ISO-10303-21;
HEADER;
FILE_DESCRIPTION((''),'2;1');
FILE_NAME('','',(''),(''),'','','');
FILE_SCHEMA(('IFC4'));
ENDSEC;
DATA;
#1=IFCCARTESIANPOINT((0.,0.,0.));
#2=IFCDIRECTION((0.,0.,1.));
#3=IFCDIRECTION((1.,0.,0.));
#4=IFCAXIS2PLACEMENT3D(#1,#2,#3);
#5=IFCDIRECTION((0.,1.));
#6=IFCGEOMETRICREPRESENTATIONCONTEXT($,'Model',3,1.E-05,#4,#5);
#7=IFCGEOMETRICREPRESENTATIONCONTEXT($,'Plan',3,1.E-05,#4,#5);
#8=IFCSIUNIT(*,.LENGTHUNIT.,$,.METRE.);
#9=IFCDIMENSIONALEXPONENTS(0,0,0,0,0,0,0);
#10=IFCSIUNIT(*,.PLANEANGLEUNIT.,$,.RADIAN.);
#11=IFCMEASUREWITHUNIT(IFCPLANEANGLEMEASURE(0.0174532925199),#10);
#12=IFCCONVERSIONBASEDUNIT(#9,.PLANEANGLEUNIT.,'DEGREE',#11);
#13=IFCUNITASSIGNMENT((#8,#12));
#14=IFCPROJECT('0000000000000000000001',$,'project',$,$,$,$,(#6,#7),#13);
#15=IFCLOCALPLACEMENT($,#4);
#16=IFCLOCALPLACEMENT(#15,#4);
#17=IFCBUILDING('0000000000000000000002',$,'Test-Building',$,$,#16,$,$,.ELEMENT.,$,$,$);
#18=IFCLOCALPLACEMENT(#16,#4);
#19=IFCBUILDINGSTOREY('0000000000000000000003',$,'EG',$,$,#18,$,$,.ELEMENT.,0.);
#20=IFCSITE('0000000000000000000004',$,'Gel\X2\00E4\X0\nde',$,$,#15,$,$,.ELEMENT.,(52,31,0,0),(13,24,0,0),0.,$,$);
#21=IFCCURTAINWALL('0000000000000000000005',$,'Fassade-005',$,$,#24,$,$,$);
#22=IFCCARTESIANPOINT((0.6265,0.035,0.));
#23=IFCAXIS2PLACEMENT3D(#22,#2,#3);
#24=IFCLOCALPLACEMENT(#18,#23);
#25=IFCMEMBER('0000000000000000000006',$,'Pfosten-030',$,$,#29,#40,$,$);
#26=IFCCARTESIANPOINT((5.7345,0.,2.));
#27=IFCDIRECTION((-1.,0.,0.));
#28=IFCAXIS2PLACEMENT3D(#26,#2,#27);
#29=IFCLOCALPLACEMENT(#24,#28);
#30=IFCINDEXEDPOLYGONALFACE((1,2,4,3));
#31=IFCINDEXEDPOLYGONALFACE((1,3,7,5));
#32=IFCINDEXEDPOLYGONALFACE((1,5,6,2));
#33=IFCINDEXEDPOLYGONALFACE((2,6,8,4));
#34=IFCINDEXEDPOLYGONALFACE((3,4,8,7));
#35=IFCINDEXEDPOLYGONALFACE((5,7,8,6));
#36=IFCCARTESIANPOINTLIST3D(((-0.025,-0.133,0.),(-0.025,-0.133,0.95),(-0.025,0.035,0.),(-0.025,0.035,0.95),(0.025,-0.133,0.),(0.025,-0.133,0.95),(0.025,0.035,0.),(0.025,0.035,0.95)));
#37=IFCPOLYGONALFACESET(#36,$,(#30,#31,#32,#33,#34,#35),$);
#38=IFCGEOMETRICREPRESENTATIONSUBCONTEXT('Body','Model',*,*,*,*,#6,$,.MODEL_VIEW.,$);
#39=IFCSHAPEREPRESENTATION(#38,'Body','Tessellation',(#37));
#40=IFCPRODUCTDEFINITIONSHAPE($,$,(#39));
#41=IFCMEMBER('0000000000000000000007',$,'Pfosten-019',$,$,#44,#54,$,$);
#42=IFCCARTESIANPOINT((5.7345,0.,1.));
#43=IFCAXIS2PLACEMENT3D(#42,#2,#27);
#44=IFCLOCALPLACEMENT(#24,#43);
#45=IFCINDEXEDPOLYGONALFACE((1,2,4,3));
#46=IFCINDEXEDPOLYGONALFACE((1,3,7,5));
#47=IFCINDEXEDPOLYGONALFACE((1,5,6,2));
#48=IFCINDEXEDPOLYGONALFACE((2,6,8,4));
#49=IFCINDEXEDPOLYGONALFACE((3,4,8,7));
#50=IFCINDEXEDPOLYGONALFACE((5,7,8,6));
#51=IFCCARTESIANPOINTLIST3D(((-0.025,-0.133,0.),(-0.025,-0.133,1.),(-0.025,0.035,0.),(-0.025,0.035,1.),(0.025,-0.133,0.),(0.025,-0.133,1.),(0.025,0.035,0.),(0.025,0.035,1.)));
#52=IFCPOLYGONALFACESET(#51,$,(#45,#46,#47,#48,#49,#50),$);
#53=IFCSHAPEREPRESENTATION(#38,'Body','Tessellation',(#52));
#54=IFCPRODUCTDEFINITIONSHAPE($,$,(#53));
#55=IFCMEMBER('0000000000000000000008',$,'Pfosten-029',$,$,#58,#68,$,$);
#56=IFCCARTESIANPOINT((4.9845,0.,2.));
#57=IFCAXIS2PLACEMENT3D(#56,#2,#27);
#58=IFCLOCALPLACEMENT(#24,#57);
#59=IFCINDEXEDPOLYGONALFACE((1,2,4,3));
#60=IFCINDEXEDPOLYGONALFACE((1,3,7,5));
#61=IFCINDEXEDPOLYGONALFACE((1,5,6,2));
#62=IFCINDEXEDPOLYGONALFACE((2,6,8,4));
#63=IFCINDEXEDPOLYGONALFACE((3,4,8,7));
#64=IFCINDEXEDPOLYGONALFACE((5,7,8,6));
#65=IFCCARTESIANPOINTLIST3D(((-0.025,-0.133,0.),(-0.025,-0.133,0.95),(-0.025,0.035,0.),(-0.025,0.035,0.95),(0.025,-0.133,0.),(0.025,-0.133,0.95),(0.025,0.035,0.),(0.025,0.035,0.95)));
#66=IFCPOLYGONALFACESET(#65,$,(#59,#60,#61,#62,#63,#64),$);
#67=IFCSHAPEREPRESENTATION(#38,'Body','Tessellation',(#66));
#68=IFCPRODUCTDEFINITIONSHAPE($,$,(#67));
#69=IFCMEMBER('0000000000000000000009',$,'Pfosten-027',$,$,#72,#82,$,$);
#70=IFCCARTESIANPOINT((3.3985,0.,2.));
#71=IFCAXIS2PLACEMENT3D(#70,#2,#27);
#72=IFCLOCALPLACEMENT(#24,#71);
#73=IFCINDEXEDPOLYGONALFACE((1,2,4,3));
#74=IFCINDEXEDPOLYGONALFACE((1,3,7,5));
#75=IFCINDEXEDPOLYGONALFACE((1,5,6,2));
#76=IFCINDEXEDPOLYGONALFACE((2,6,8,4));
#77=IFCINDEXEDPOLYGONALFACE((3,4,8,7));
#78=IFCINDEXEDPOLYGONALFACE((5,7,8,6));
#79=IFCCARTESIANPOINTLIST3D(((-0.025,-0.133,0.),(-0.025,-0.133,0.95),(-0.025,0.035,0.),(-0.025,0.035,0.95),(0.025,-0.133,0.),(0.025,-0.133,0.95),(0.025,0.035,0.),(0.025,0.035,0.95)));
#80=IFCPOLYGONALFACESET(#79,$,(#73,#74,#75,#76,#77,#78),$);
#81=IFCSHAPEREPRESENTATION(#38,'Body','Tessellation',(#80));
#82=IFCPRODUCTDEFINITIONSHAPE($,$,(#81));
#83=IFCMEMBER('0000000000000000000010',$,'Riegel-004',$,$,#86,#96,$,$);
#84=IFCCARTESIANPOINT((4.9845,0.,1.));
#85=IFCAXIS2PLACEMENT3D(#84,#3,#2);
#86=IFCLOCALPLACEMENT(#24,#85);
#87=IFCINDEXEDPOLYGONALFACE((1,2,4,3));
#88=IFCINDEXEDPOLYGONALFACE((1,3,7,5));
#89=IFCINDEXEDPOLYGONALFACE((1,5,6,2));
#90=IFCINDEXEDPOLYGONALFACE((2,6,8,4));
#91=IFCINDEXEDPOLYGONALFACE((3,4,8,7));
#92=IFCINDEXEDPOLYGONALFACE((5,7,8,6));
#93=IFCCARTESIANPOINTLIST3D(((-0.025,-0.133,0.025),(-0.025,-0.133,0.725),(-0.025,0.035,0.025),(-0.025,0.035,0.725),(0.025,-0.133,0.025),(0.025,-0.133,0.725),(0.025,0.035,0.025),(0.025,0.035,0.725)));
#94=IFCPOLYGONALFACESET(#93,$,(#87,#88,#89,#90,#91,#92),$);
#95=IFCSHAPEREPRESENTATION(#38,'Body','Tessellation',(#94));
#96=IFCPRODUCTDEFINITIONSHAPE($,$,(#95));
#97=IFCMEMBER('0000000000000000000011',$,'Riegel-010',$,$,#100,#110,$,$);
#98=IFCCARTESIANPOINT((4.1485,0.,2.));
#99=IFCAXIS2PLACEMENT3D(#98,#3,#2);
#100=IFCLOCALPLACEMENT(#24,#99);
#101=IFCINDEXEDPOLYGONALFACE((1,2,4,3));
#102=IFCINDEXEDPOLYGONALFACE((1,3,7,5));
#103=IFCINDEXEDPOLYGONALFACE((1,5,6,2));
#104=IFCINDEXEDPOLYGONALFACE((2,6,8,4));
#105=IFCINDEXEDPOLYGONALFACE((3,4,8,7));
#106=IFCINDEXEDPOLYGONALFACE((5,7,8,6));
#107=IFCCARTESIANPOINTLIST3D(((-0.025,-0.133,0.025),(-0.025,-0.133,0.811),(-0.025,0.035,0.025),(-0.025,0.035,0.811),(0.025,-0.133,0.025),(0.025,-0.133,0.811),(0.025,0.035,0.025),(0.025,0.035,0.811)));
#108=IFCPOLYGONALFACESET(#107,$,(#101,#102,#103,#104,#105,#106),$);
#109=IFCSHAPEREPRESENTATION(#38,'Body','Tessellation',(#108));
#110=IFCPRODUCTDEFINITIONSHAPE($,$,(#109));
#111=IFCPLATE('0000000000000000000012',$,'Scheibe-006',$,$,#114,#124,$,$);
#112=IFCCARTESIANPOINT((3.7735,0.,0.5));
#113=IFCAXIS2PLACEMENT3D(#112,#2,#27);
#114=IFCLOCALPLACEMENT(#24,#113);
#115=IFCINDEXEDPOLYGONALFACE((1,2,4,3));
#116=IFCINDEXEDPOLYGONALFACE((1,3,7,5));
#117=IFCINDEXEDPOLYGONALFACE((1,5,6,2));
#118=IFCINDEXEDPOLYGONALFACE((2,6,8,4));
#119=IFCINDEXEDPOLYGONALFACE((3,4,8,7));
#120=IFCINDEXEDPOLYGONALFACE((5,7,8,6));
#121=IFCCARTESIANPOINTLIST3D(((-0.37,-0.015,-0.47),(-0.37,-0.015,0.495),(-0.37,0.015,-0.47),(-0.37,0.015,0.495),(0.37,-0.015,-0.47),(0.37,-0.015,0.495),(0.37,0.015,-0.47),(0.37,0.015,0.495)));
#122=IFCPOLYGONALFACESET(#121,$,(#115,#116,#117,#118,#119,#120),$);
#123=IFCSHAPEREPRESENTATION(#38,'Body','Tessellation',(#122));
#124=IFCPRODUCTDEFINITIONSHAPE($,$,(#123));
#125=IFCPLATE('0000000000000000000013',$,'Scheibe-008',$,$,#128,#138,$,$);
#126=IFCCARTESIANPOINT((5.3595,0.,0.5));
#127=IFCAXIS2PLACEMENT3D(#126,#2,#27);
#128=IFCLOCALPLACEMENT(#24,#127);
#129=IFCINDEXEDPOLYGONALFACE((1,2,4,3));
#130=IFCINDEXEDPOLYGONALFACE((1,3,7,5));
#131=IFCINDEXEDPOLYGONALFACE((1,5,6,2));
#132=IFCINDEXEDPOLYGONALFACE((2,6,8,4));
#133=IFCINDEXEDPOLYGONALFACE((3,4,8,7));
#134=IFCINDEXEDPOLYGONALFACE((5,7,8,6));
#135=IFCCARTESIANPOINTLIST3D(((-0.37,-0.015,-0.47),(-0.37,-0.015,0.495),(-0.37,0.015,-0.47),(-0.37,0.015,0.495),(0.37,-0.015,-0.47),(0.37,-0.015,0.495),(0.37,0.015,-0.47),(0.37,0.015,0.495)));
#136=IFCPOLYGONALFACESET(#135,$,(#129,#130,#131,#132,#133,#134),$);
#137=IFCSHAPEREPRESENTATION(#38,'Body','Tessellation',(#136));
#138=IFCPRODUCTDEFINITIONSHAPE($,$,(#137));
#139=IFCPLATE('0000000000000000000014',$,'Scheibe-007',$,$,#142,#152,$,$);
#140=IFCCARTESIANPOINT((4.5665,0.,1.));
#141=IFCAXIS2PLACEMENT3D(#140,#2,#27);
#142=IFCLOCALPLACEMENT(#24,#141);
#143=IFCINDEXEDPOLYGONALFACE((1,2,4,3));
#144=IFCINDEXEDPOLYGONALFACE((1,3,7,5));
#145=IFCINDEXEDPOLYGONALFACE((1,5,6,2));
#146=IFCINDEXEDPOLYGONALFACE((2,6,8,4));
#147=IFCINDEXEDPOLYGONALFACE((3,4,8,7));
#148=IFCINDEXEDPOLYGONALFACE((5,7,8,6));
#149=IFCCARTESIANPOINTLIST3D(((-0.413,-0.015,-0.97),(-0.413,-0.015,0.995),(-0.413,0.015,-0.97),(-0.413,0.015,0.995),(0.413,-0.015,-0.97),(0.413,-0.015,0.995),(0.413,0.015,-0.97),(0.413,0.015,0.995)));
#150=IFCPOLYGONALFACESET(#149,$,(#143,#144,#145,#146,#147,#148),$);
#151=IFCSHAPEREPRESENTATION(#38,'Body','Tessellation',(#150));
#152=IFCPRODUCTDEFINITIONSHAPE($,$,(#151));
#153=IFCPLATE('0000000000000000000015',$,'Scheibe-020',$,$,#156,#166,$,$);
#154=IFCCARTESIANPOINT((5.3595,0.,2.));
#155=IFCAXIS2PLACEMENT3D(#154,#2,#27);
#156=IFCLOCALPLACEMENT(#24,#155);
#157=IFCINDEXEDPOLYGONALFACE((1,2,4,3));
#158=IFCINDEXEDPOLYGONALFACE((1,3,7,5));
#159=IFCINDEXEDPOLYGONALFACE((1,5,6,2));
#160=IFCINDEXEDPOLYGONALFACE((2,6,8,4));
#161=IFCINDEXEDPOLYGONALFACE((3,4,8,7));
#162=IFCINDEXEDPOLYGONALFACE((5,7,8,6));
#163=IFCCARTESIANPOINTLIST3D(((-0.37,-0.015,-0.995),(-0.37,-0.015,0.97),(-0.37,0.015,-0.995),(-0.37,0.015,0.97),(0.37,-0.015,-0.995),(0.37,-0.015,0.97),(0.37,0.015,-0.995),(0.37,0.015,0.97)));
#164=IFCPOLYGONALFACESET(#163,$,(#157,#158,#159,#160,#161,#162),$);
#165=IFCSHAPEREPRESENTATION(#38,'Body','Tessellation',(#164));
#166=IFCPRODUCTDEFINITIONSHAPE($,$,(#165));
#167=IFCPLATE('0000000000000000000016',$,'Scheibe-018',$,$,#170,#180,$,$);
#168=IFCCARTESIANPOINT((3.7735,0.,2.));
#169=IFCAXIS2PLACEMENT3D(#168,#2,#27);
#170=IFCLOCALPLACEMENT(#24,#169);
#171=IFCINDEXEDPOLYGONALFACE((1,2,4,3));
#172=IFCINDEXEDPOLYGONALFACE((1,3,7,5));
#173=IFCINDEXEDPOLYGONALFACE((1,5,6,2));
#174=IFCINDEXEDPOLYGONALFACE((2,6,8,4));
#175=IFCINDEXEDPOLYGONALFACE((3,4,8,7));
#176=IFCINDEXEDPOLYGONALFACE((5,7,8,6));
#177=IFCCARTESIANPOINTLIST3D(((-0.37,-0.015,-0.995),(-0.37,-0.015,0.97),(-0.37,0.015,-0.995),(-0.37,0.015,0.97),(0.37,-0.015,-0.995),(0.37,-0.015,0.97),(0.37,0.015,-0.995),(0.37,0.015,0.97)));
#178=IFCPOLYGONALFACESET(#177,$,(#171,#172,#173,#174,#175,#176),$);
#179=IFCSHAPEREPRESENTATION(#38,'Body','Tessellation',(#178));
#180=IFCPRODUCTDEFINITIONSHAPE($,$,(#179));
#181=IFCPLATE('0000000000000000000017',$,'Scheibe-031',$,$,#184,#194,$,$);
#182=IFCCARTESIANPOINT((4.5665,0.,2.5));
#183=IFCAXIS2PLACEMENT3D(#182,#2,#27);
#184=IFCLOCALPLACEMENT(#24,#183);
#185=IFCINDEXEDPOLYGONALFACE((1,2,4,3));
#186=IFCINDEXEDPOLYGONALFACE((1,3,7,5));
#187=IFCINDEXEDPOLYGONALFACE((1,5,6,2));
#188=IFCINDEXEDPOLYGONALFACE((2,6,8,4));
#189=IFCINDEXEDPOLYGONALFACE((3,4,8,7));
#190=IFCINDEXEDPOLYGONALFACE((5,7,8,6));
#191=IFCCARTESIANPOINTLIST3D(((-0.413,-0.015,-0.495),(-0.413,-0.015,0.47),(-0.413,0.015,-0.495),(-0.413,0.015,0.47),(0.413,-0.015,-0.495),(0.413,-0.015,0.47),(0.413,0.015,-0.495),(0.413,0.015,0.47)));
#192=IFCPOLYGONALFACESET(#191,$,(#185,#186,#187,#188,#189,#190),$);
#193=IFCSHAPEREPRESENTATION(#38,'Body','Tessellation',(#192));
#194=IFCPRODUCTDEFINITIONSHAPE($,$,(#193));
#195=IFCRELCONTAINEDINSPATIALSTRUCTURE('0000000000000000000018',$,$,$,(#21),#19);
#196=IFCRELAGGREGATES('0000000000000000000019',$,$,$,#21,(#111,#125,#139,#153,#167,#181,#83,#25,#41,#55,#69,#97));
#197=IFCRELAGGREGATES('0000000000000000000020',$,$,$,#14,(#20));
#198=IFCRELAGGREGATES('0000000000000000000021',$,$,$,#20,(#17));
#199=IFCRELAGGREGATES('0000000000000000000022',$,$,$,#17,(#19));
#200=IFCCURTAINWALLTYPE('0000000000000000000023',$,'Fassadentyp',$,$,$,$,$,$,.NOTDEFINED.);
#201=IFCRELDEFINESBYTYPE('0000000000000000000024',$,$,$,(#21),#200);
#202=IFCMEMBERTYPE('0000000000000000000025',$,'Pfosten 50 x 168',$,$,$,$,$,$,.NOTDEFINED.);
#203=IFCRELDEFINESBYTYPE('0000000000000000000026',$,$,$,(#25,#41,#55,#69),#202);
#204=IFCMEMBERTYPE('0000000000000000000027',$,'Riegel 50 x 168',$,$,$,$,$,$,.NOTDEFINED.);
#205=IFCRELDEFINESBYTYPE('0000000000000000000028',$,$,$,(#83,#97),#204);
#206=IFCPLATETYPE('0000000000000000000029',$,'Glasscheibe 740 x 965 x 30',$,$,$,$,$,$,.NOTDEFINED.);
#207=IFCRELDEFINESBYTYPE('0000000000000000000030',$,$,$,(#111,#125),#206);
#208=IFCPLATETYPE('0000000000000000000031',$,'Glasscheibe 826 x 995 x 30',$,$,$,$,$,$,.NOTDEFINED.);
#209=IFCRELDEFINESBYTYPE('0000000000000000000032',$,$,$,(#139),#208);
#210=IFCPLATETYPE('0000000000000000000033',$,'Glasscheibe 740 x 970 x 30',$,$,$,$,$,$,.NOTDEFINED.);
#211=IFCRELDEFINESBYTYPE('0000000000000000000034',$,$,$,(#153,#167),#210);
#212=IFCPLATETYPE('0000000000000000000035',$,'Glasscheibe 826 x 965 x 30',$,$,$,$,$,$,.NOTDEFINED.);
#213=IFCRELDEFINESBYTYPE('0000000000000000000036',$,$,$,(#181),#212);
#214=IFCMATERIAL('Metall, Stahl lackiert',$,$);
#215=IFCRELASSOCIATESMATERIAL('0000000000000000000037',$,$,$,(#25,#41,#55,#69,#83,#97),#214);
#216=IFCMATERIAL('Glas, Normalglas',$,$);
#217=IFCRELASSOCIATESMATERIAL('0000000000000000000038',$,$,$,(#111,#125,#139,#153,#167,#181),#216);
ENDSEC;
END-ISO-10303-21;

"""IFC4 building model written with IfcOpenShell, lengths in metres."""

from ifc_helpers import new_model, entity, si_unit, converted_unit, direction, frame, origin_with_axes, place, context, subcontext, project, spatial, polyline, outline, extrude, material, type_object, element, aggregate, save


model = new_model("IFC4")

# Units and contexts
model_context = context("Model", 3, precision=1e-05, world=origin_with_axes(), true_north=direction((0.0, 1.0)))
plan_context = context("Plan", 3, precision=1e-05, world=origin_with_axes(), true_north=direction((0.0, 1.0)))
body_context = subcontext(model_context, "Body", "Model", "MODEL_VIEW")
ifc_project = project(units=[si_unit("LENGTHUNIT", "METRE"), converted_unit("PLANEANGLEUNIT", "DEGREE", entity("IfcPlaneAngleMeasure", 0.0174532925199), si_unit("PLANEANGLEUNIT", "RADIAN"), dimensions=[0, 0, 0, 0, 0, 0, 0])], contexts=[model_context, plan_context])

# Site, building, storey
site_placement = place(None, origin_with_axes())
site = spatial("IfcSite", under=ifc_project, at=site_placement, Name="Gelände", CompositionType="ELEMENT", RefLatitude=(52, 31, 0, 0), RefLongitude=(13, 24, 0, 0), RefElevation=0.0)
building_placement = place(site_placement, origin_with_axes())
building = spatial("IfcBuilding", under=site, at=building_placement, Name="Test-Building", CompositionType="ELEMENT")
storey_placement = place(building_placement, origin_with_axes())
storey = spatial("IfcBuildingStorey", under=building, at=storey_placement, Name="EG", CompositionType="ELEMENT", Elevation=0.0)

# Curtain wall, members, plates
curtain_wall_type = type_object("IfcCurtainWallType", Name="Fassadentyp", PredefinedType="NOTDEFINED")
curtain_wall_placement = place(storey_placement, frame((0.6265, 0.035, 0.0), z_axis=(0.0, 0.0, 1.0), x_axis=(1.0, 0.0, 0.0)))
curtain_wall = element("IfcCurtainWall", 1, at=curtain_wall_placement, inside=storey, type_object=curtain_wall_type, Name="Fassade-005")
ifc_material_1 = material(Name="Metall, Stahl lackiert")
member_type_1 = type_object("IfcMemberType", Name="Pfosten 50 x 168", PredefinedType="NOTDEFINED")
member_1_placement = place(curtain_wall_placement, frame((5.7345, 0.0, 2.0), z_axis=(0.0, 0.0, 1.0), x_axis=(-1.0, 0.0, 0.0)))
member_1 = element("IfcMember", 2, at=member_1_placement, type_object=member_type_1, material=ifc_material_1, Name="Pfosten-030", context=body_context, shape_type="SweptSolid", body=[
    extrude(outline(polyline([(-0.025, 0.133), (-0.025, -0.035), (0.025, -0.035), (0.025, 0.133), (-0.025, 0.133)])), frame((0.0, 0.0, 0.0), z_axis=(0.0, 0.0, 1.0), x_axis=(-1.0, 0.0, 0.0)), (0.0, 0.0, 1.0), 0.95),
])
member_2_placement = place(curtain_wall_placement, frame((5.7345, 0.0, 1.0), z_axis=(0.0, 0.0, 1.0), x_axis=(-1.0, 0.0, 0.0)))
member_2 = element("IfcMember", 3, at=member_2_placement, type_object=member_type_1, material=ifc_material_1, Name="Pfosten-019", context=body_context, shape_type="SweptSolid", body=[
    extrude(outline(polyline([(-0.025, 0.133), (-0.025, -0.035), (0.025, -0.035), (0.025, 0.133), (-0.025, 0.133)])), frame((0.0, 0.0, 0.0), z_axis=(0.0, 0.0, 1.0), x_axis=(-1.0, 0.0, 0.0)), (0.0, 0.0, 1.0), 1.0),
])
member_3_placement = place(curtain_wall_placement, frame((4.9845, 0.0, 2.0), z_axis=(0.0, 0.0, 1.0), x_axis=(-1.0, 0.0, 0.0)))
member_3 = element("IfcMember", 4, at=member_3_placement, type_object=member_type_1, material=ifc_material_1, Name="Pfosten-029", context=body_context, shape_type="SweptSolid", body=[
    extrude(outline(polyline([(-0.025, 0.133), (-0.025, -0.035), (0.025, -0.035), (0.025, 0.133), (-0.025, 0.133)])), frame((0.0, 0.0, 0.0), z_axis=(0.0, 0.0, 1.0), x_axis=(-1.0, 0.0, 0.0)), (0.0, 0.0, 1.0), 0.95),
])
member_4_placement = place(curtain_wall_placement, frame((3.3985, 0.0, 2.0), z_axis=(0.0, 0.0, 1.0), x_axis=(-1.0, 0.0, 0.0)))
member_4 = element("IfcMember", 5, at=member_4_placement, type_object=member_type_1, material=ifc_material_1, Name="Pfosten-027", context=body_context, shape_type="SweptSolid", body=[
    extrude(outline(polyline([(-0.025, 0.133), (-0.025, -0.035), (0.025, -0.035), (0.025, 0.133), (-0.025, 0.133)])), frame((0.0, 0.0, 0.0), z_axis=(0.0, 0.0, 1.0), x_axis=(-1.0, 0.0, 0.0)), (0.0, 0.0, 1.0), 0.95),
])
member_type_2 = type_object("IfcMemberType", Name="Riegel 50 x 168", PredefinedType="NOTDEFINED")
member_5_placement = place(curtain_wall_placement, frame((4.9845, 0.0, 1.0), z_axis=(1.0, 0.0, 0.0), x_axis=(0.0, 0.0, 1.0)))
member_5 = element("IfcMember", 6, at=member_5_placement, type_object=member_type_2, material=ifc_material_1, Name="Riegel-004", context=body_context, shape_type="SweptSolid", body=[
    extrude(outline(polyline([(-0.133, -0.025), (0.035, -0.025), (0.035, 0.025), (-0.133, 0.025), (-0.133, -0.025)])), frame((0.0, 0.0, 0.025), z_axis=(0.0, 0.0, 1.0), x_axis=(0.0, 1.0, 0.0)), (0.0, 0.0, 1.0), 0.7),
])
member_6_placement = place(curtain_wall_placement, frame((4.1485, 0.0, 2.0), z_axis=(1.0, 0.0, 0.0), x_axis=(0.0, 0.0, 1.0)))
member_6 = element("IfcMember", 7, at=member_6_placement, type_object=member_type_2, material=ifc_material_1, Name="Riegel-010", context=body_context, shape_type="SweptSolid", body=[
    extrude(outline(polyline([(-0.133, -0.025), (0.035, -0.025), (0.035, 0.025), (-0.133, 0.025), (-0.133, -0.025)])), frame((0.0, 0.0, 0.025), z_axis=(0.0, 0.0, 1.0), x_axis=(0.0, 1.0, 0.0)), (0.0, 0.0, 1.0), 0.786),
])
ifc_material_2 = material(Name="Glas, Normalglas")
plate_type_1 = type_object("IfcPlateType", Name="Glasscheibe 740 x 965 x 30", PredefinedType="NOTDEFINED")
plate_1_placement = place(curtain_wall_placement, frame((3.7735, 0.0, 0.5), z_axis=(0.0, 0.0, 1.0), x_axis=(-1.0, 0.0, 0.0)))
plate_1 = element("IfcPlate", 8, at=plate_1_placement, type_object=plate_type_1, material=ifc_material_2, Name="Scheibe-006", context=body_context, shape_type="SweptSolid", body=[
    extrude(outline(polyline([(-0.37, -0.495), (0.37, -0.495), (0.37, 0.47), (-0.37, 0.47), (-0.37, -0.495)])), frame((0.0, -0.015, 0.0), z_axis=(0.0, 1.0, 0.0), x_axis=(1.0, 0.0, 0.0)), (0.0, 0.0, 1.0), 0.03),
])
plate_2_placement = place(curtain_wall_placement, frame((5.3595, 0.0, 0.5), z_axis=(0.0, 0.0, 1.0), x_axis=(-1.0, 0.0, 0.0)))
plate_2 = element("IfcPlate", 9, at=plate_2_placement, type_object=plate_type_1, material=ifc_material_2, Name="Scheibe-008", context=body_context, shape_type="SweptSolid", body=[
    extrude(outline(polyline([(-0.37, -0.495), (0.37, -0.495), (0.37, 0.47), (-0.37, 0.47), (-0.37, -0.495)])), frame((0.0, -0.015, 0.0), z_axis=(0.0, 1.0, 0.0), x_axis=(1.0, 0.0, 0.0)), (0.0, 0.0, 1.0), 0.03),
])
plate_type_2 = type_object("IfcPlateType", Name="Glasscheibe 826 x 995 x 30", PredefinedType="NOTDEFINED")
plate_3_placement = place(curtain_wall_placement, frame((4.5665, 0.0, 1.0), z_axis=(0.0, 0.0, 1.0), x_axis=(-1.0, 0.0, 0.0)))
plate_3 = element("IfcPlate", 10, at=plate_3_placement, type_object=plate_type_2, material=ifc_material_2, Name="Scheibe-007", context=body_context, shape_type="SweptSolid", body=[
    extrude(outline(polyline([(-0.413, -0.995), (0.413, -0.995), (0.413, 0.97), (-0.413, 0.97), (-0.413, -0.995)])), frame((0.0, -0.015, 0.0), z_axis=(0.0, 1.0, 0.0), x_axis=(1.0, 0.0, 0.0)), (0.0, 0.0, 1.0), 0.03),
])
plate_type_3 = type_object("IfcPlateType", Name="Glasscheibe 740 x 970 x 30", PredefinedType="NOTDEFINED")
plate_4_placement = place(curtain_wall_placement, frame((5.3595, 0.0, 2.0), z_axis=(0.0, 0.0, 1.0), x_axis=(-1.0, 0.0, 0.0)))
plate_4 = element("IfcPlate", 11, at=plate_4_placement, type_object=plate_type_3, material=ifc_material_2, Name="Scheibe-020", context=body_context, shape_type="SweptSolid", body=[
    extrude(outline(polyline([(-0.37, -0.97), (0.37, -0.97), (0.37, 0.995), (-0.37, 0.995), (-0.37, -0.97)])), frame((0.0, -0.015, 0.0), z_axis=(0.0, 1.0, 0.0), x_axis=(1.0, 0.0, 0.0)), (0.0, 0.0, 1.0), 0.03),
])
plate_5_placement = place(curtain_wall_placement, frame((3.7735, 0.0, 2.0), z_axis=(0.0, 0.0, 1.0), x_axis=(-1.0, 0.0, 0.0)))
plate_5 = element("IfcPlate", 12, at=plate_5_placement, type_object=plate_type_3, material=ifc_material_2, Name="Scheibe-018", context=body_context, shape_type="SweptSolid", body=[
    extrude(outline(polyline([(-0.37, -0.97), (0.37, -0.97), (0.37, 0.995), (-0.37, 0.995), (-0.37, -0.97)])), frame((0.0, -0.015, 0.0), z_axis=(0.0, 1.0, 0.0), x_axis=(1.0, 0.0, 0.0)), (0.0, 0.0, 1.0), 0.03),
])
plate_type_4 = type_object("IfcPlateType", Name="Glasscheibe 826 x 965 x 30", PredefinedType="NOTDEFINED")
plate_6_placement = place(curtain_wall_placement, frame((4.5665, 0.0, 2.5), z_axis=(0.0, 0.0, 1.0), x_axis=(-1.0, 0.0, 0.0)))
plate_6 = element("IfcPlate", 13, at=plate_6_placement, type_object=plate_type_4, material=ifc_material_2, Name="Scheibe-031", context=body_context, shape_type="SweptSolid", body=[
    extrude(outline(polyline([(-0.413, -0.47), (0.413, -0.47), (0.413, 0.495), (-0.413, 0.495), (-0.413, -0.47)])), frame((0.0, -0.015, 0.0), z_axis=(0.0, 1.0, 0.0), x_axis=(1.0, 0.0, 0.0)), (0.0, 0.0, 1.0), 0.03),
])
aggregate(curtain_wall, [plate_1, plate_2, plate_3, plate_4, plate_5, plate_6, member_5, member_1, member_2, member_3, member_4, member_6])

save(model, "model.ifc")
